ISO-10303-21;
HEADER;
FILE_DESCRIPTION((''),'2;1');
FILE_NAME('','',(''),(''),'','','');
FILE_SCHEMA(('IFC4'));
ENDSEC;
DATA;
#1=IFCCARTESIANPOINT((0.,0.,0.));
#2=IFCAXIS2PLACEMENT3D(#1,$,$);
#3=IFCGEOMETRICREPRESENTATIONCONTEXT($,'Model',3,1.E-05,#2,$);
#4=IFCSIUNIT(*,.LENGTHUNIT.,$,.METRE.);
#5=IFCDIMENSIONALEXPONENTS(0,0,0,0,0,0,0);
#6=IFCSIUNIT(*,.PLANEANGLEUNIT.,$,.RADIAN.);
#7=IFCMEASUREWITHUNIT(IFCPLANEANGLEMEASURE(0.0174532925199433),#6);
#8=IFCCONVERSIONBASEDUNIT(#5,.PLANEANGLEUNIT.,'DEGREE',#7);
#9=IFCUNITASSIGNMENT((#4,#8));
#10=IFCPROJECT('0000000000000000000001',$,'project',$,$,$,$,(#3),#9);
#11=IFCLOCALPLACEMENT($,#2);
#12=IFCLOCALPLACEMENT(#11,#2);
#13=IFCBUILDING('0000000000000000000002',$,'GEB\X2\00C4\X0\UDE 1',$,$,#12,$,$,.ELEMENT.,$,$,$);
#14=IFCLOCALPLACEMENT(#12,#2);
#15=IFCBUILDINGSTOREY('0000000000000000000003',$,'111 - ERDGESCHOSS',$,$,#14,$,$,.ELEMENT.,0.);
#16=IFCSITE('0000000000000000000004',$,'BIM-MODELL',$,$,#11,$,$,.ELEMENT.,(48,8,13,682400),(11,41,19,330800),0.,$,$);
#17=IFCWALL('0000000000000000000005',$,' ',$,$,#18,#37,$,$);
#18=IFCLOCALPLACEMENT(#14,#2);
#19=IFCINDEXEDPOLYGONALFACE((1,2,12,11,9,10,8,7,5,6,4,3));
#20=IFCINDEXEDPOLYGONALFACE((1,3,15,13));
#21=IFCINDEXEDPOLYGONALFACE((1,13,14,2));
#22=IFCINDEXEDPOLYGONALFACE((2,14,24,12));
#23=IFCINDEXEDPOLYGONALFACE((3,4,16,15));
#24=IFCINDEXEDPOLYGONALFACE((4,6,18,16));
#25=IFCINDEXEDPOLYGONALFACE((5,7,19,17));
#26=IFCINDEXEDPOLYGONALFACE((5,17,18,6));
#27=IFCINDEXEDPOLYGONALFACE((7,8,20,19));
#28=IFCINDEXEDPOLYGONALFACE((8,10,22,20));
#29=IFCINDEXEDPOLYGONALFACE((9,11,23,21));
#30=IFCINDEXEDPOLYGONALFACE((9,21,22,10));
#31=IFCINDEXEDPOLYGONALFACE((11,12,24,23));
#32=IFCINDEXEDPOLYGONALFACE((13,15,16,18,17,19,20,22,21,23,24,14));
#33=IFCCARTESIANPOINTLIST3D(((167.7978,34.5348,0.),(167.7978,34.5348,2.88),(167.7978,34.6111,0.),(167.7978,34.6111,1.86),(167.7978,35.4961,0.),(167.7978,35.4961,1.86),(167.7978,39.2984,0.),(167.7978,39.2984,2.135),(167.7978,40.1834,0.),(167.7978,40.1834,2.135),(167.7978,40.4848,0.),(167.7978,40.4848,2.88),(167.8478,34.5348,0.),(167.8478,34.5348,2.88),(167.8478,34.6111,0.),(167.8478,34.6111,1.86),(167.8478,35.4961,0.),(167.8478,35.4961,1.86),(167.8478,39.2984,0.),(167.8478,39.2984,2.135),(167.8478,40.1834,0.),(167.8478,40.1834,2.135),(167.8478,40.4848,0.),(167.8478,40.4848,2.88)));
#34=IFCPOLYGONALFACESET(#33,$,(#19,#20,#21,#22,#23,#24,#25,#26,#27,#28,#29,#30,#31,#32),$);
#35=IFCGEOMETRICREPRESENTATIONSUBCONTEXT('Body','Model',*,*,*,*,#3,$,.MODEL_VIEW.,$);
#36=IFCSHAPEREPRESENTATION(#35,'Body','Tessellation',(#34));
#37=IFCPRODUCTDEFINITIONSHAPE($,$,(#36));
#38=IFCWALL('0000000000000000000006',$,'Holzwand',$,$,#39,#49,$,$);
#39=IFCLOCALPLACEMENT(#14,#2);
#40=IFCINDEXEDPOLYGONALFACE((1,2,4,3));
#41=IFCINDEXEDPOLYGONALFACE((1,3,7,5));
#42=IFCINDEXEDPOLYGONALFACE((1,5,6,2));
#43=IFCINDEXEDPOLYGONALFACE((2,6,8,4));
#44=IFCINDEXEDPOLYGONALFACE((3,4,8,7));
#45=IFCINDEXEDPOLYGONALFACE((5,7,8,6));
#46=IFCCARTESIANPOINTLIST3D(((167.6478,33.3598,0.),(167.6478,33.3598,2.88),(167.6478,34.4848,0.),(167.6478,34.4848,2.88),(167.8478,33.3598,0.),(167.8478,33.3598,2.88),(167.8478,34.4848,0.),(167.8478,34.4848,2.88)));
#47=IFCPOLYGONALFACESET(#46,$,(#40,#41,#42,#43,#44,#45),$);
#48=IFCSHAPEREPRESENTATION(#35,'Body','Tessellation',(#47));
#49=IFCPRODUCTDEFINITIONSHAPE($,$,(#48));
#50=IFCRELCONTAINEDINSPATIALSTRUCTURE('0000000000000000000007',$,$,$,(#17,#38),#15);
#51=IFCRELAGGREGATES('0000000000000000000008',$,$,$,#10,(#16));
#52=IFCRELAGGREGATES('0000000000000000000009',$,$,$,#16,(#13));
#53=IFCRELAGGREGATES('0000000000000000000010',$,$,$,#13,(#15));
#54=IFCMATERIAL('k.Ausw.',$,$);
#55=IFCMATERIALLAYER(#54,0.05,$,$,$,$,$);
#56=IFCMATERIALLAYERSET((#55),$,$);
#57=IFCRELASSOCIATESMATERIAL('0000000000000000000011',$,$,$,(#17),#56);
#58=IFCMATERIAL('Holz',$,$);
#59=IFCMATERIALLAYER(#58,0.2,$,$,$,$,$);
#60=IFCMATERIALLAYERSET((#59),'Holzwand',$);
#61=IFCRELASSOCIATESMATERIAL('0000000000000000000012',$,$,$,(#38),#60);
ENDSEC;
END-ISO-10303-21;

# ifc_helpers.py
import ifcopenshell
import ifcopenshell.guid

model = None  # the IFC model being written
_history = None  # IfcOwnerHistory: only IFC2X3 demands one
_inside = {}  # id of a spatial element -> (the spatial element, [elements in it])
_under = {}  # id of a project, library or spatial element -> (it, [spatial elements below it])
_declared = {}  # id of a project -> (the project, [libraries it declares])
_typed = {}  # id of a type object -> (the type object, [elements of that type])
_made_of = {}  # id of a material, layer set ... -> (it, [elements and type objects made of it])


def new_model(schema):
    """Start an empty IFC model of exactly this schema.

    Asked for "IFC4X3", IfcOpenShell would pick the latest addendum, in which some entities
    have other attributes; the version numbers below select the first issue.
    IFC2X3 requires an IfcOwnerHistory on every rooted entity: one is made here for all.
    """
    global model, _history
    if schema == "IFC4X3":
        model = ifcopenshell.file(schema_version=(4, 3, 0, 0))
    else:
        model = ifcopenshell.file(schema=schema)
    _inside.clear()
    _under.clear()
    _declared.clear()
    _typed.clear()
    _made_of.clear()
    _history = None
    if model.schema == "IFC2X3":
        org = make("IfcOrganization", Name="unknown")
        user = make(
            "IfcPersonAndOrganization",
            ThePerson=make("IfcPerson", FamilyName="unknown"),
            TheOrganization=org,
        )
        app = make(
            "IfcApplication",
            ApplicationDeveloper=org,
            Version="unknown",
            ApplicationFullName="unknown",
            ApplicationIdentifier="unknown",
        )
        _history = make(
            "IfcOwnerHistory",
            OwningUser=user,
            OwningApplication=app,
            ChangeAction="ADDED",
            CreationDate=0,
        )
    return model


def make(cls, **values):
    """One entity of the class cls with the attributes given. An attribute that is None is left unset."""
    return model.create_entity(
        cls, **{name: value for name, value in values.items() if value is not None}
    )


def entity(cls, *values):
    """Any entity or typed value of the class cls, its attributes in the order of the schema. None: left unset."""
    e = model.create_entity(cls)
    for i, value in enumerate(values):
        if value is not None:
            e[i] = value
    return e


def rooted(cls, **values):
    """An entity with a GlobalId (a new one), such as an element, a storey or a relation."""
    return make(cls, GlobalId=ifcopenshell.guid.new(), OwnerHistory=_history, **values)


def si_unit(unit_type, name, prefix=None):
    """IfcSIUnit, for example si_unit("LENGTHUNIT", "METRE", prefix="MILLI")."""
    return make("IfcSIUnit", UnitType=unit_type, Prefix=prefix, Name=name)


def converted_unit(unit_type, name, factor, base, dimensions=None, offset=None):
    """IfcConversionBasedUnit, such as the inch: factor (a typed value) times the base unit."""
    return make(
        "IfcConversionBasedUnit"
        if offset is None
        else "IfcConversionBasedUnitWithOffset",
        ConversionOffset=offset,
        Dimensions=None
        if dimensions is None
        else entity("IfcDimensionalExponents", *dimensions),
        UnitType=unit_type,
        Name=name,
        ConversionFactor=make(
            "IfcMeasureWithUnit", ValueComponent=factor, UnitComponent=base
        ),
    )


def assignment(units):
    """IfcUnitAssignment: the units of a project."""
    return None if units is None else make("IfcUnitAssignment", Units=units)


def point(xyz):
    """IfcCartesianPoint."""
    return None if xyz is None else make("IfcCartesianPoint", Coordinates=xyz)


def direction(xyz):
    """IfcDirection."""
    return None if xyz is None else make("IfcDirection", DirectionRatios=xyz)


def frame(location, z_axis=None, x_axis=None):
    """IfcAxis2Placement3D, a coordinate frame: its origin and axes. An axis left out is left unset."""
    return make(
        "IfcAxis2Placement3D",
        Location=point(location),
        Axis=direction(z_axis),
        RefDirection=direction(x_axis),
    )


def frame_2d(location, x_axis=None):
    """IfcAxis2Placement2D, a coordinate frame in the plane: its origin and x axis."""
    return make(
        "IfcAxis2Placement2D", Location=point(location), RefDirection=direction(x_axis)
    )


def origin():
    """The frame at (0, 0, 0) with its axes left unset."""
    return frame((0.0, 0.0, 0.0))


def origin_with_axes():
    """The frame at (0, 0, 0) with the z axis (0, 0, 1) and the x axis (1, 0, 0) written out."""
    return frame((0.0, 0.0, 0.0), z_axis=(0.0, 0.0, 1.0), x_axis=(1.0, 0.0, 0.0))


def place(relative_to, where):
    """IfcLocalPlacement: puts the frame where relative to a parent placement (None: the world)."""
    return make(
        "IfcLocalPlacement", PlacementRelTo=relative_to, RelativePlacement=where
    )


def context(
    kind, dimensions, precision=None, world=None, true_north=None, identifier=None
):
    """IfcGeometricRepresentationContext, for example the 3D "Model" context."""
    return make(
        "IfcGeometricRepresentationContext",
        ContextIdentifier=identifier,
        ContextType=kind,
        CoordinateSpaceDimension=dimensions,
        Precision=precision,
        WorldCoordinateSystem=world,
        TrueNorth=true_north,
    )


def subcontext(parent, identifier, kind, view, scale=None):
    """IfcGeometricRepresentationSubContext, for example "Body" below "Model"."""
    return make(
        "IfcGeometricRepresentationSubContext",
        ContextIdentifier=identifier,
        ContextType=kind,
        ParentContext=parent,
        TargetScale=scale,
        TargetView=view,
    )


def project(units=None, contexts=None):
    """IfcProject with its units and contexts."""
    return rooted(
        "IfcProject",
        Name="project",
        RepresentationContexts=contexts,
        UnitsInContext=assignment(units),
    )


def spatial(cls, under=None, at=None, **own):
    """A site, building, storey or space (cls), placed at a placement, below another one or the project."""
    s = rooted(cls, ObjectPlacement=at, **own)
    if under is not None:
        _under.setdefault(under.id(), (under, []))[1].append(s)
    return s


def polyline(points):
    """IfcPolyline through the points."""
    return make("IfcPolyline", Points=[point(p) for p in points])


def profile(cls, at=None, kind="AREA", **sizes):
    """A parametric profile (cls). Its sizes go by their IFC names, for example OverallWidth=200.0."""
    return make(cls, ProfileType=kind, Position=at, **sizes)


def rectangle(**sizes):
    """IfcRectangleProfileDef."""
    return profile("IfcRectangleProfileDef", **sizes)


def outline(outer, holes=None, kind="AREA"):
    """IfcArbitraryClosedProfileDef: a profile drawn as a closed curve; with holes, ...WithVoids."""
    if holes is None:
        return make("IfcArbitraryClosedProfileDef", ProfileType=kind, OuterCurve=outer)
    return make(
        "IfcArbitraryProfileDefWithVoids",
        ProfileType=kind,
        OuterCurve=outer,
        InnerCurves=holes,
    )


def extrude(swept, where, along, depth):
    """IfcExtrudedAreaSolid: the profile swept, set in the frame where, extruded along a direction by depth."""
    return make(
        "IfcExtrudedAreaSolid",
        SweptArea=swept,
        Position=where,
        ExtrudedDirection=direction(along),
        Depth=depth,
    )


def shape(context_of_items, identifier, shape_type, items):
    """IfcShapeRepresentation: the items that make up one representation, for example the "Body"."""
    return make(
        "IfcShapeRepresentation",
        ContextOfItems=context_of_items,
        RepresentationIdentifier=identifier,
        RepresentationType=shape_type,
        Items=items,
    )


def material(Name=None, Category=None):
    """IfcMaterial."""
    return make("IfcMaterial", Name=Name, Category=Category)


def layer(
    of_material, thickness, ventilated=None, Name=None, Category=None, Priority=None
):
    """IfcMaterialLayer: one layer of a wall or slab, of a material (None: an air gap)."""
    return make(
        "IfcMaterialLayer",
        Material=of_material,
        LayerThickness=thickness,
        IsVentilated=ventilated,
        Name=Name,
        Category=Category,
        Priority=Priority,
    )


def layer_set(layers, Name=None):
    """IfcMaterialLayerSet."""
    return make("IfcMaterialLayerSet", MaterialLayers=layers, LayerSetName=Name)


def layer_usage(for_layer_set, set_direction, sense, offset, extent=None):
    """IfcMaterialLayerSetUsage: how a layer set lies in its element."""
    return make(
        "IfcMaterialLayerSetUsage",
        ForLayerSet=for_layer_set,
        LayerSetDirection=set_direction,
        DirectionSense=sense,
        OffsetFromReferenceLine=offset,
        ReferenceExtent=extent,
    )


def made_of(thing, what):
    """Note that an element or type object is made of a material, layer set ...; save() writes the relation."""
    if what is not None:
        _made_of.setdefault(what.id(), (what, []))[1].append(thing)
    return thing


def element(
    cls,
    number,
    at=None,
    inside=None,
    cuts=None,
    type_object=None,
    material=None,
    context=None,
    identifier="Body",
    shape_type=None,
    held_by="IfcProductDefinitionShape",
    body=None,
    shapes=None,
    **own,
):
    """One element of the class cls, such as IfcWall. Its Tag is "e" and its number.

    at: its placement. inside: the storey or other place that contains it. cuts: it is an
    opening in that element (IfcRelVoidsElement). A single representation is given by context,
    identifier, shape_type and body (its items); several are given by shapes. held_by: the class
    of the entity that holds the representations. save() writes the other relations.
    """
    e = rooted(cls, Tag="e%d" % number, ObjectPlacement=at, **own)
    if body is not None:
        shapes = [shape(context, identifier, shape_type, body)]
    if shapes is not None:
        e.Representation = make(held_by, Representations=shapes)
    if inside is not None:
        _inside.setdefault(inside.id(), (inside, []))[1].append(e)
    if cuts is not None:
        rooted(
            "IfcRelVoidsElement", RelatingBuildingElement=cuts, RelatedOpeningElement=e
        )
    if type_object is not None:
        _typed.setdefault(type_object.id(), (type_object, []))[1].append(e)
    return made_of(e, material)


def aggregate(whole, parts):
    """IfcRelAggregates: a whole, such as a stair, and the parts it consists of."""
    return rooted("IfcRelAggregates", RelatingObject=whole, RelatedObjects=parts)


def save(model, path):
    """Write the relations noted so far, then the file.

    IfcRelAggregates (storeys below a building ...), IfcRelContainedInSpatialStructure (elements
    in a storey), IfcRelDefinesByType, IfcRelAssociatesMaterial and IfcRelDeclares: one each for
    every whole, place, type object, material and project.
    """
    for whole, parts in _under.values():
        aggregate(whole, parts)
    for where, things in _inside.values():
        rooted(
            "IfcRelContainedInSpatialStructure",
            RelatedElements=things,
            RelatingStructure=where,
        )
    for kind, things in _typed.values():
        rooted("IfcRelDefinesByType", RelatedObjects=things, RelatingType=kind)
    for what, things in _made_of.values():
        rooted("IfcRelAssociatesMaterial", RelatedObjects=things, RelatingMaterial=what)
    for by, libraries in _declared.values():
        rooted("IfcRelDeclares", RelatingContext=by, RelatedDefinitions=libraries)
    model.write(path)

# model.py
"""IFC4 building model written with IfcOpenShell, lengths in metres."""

from ifc_helpers import new_model, entity, si_unit, converted_unit, frame, frame_2d, origin, origin_with_axes, place, context, subcontext, project, spatial, polyline, rectangle, outline, extrude, material, layer, layer_set, layer_usage, element, save


model = new_model("IFC4")

# Units and contexts
model_context = context("Model", 3, precision=1e-05, world=origin())
body_context = subcontext(model_context, "Body", "Model", "MODEL_VIEW")
ifc_project = project(units=[si_unit("LENGTHUNIT", "METRE"), converted_unit("PLANEANGLEUNIT", "DEGREE", entity("IfcPlaneAngleMeasure", 0.0174532925199433), si_unit("PLANEANGLEUNIT", "RADIAN"), dimensions=[0, 0, 0, 0, 0, 0, 0])], contexts=[model_context])

# Site, building, storey
site_placement = place(None, origin())
site = spatial("IfcSite", under=ifc_project, at=site_placement, Name="BIM-MODELL", CompositionType="ELEMENT", RefLatitude=(48, 8, 13, 682400), RefLongitude=(11, 41, 19, 330800), RefElevation=0.0)
building_placement = place(site_placement, origin())
building = spatial("IfcBuilding", under=site, at=building_placement, Name="GEBÄUDE 1", CompositionType="ELEMENT")
storey_placement = place(building_placement, origin())
storey = spatial("IfcBuildingStorey", under=building, at=storey_placement, Name="111 - ERDGESCHOSS", CompositionType="ELEMENT", Elevation=0.0)

# Wall, openings
ifc_material_1 = material(Name="k.Ausw.")
ifc_layer_1 = layer(ifc_material_1, 0.05)
ifc_layer_set_1 = layer_set([ifc_layer_1])
ifc_layer_usage_1 = layer_usage(ifc_layer_set_1, "AXIS2", "POSITIVE", 0.0)
wall_1_placement = place(storey_placement, frame((167.8478, 34.5348, 0.0), z_axis=(0.0, 0.0, 1.0), x_axis=(0.0, 1.0, 0.0)))
wall_1 = element("IfcWall", 1, at=wall_1_placement, inside=storey, material=ifc_layer_usage_1, Name=" ", context=body_context, shape_type="SweptSolid", body=[
    extrude(rectangle(XDim=5.95, YDim=0.05, at=frame_2d((2.975, 0.025), x_axis=(1.0, 0.0))), origin_with_axes(), (0.0, 0.0, 1.0), 2.88),
])
opening_1_placement = place(wall_1_placement, frame((0.9613, 0.05, -0.15), z_axis=(0.0, -1.0, 0.0), x_axis=(0.0, 0.0, 1.0)))
element("IfcOpeningElement", 2, at=opening_1_placement, cuts=wall_1, ObjectType="Opening", context=body_context, shape_type="SweptSolid", body=[
    extrude(outline(polyline([(0.0, 0.885), (2.01, 0.885), (2.01, 0.0), (0.0, 0.0), (0.0, 0.885)])), origin_with_axes(), (0.0, 0.0, 1.0), 0.05),
])
opening_2_placement = place(wall_1_placement, frame((4.7636, 0.0, 0.0), z_axis=(0.0, 1.0, 0.0), x_axis=(0.0, 0.0, 1.0)))
element("IfcOpeningElement", 3, at=opening_2_placement, cuts=wall_1, ObjectType="Opening", context=body_context, shape_type="SweptSolid", body=[
    extrude(outline(polyline([(0.0, 0.885), (2.135, 0.885), (2.135, 0.0), (0.0, 0.0), (0.0, 0.885)])), origin_with_axes(), (0.0, 0.0, 1.0), 0.05),
])

# Wall
ifc_material_2 = material(Name="Holz")
ifc_layer_2 = layer(ifc_material_2, 0.2)
ifc_layer_set_2 = layer_set([ifc_layer_2], Name="Holzwand")
ifc_layer_usage_2 = layer_usage(ifc_layer_set_2, "AXIS2", "POSITIVE", 0.0)
wall_2_placement = place(storey_placement, frame((167.8478, 33.3598, 0.0), z_axis=(0.0, 0.0, 1.0), x_axis=(0.0, 1.0, 0.0)))
element("IfcWall", 4, at=wall_2_placement, inside=storey, material=ifc_layer_usage_2, Name="Holzwand", context=body_context, shape_type="SweptSolid", body=[
    extrude(rectangle(XDim=1.125, YDim=0.2, at=frame_2d((0.5625, 0.1), x_axis=(1.0, 0.0))), origin_with_axes(), (0.0, 0.0, 1.0), 2.88),
])

save(model, "model.ifc")
